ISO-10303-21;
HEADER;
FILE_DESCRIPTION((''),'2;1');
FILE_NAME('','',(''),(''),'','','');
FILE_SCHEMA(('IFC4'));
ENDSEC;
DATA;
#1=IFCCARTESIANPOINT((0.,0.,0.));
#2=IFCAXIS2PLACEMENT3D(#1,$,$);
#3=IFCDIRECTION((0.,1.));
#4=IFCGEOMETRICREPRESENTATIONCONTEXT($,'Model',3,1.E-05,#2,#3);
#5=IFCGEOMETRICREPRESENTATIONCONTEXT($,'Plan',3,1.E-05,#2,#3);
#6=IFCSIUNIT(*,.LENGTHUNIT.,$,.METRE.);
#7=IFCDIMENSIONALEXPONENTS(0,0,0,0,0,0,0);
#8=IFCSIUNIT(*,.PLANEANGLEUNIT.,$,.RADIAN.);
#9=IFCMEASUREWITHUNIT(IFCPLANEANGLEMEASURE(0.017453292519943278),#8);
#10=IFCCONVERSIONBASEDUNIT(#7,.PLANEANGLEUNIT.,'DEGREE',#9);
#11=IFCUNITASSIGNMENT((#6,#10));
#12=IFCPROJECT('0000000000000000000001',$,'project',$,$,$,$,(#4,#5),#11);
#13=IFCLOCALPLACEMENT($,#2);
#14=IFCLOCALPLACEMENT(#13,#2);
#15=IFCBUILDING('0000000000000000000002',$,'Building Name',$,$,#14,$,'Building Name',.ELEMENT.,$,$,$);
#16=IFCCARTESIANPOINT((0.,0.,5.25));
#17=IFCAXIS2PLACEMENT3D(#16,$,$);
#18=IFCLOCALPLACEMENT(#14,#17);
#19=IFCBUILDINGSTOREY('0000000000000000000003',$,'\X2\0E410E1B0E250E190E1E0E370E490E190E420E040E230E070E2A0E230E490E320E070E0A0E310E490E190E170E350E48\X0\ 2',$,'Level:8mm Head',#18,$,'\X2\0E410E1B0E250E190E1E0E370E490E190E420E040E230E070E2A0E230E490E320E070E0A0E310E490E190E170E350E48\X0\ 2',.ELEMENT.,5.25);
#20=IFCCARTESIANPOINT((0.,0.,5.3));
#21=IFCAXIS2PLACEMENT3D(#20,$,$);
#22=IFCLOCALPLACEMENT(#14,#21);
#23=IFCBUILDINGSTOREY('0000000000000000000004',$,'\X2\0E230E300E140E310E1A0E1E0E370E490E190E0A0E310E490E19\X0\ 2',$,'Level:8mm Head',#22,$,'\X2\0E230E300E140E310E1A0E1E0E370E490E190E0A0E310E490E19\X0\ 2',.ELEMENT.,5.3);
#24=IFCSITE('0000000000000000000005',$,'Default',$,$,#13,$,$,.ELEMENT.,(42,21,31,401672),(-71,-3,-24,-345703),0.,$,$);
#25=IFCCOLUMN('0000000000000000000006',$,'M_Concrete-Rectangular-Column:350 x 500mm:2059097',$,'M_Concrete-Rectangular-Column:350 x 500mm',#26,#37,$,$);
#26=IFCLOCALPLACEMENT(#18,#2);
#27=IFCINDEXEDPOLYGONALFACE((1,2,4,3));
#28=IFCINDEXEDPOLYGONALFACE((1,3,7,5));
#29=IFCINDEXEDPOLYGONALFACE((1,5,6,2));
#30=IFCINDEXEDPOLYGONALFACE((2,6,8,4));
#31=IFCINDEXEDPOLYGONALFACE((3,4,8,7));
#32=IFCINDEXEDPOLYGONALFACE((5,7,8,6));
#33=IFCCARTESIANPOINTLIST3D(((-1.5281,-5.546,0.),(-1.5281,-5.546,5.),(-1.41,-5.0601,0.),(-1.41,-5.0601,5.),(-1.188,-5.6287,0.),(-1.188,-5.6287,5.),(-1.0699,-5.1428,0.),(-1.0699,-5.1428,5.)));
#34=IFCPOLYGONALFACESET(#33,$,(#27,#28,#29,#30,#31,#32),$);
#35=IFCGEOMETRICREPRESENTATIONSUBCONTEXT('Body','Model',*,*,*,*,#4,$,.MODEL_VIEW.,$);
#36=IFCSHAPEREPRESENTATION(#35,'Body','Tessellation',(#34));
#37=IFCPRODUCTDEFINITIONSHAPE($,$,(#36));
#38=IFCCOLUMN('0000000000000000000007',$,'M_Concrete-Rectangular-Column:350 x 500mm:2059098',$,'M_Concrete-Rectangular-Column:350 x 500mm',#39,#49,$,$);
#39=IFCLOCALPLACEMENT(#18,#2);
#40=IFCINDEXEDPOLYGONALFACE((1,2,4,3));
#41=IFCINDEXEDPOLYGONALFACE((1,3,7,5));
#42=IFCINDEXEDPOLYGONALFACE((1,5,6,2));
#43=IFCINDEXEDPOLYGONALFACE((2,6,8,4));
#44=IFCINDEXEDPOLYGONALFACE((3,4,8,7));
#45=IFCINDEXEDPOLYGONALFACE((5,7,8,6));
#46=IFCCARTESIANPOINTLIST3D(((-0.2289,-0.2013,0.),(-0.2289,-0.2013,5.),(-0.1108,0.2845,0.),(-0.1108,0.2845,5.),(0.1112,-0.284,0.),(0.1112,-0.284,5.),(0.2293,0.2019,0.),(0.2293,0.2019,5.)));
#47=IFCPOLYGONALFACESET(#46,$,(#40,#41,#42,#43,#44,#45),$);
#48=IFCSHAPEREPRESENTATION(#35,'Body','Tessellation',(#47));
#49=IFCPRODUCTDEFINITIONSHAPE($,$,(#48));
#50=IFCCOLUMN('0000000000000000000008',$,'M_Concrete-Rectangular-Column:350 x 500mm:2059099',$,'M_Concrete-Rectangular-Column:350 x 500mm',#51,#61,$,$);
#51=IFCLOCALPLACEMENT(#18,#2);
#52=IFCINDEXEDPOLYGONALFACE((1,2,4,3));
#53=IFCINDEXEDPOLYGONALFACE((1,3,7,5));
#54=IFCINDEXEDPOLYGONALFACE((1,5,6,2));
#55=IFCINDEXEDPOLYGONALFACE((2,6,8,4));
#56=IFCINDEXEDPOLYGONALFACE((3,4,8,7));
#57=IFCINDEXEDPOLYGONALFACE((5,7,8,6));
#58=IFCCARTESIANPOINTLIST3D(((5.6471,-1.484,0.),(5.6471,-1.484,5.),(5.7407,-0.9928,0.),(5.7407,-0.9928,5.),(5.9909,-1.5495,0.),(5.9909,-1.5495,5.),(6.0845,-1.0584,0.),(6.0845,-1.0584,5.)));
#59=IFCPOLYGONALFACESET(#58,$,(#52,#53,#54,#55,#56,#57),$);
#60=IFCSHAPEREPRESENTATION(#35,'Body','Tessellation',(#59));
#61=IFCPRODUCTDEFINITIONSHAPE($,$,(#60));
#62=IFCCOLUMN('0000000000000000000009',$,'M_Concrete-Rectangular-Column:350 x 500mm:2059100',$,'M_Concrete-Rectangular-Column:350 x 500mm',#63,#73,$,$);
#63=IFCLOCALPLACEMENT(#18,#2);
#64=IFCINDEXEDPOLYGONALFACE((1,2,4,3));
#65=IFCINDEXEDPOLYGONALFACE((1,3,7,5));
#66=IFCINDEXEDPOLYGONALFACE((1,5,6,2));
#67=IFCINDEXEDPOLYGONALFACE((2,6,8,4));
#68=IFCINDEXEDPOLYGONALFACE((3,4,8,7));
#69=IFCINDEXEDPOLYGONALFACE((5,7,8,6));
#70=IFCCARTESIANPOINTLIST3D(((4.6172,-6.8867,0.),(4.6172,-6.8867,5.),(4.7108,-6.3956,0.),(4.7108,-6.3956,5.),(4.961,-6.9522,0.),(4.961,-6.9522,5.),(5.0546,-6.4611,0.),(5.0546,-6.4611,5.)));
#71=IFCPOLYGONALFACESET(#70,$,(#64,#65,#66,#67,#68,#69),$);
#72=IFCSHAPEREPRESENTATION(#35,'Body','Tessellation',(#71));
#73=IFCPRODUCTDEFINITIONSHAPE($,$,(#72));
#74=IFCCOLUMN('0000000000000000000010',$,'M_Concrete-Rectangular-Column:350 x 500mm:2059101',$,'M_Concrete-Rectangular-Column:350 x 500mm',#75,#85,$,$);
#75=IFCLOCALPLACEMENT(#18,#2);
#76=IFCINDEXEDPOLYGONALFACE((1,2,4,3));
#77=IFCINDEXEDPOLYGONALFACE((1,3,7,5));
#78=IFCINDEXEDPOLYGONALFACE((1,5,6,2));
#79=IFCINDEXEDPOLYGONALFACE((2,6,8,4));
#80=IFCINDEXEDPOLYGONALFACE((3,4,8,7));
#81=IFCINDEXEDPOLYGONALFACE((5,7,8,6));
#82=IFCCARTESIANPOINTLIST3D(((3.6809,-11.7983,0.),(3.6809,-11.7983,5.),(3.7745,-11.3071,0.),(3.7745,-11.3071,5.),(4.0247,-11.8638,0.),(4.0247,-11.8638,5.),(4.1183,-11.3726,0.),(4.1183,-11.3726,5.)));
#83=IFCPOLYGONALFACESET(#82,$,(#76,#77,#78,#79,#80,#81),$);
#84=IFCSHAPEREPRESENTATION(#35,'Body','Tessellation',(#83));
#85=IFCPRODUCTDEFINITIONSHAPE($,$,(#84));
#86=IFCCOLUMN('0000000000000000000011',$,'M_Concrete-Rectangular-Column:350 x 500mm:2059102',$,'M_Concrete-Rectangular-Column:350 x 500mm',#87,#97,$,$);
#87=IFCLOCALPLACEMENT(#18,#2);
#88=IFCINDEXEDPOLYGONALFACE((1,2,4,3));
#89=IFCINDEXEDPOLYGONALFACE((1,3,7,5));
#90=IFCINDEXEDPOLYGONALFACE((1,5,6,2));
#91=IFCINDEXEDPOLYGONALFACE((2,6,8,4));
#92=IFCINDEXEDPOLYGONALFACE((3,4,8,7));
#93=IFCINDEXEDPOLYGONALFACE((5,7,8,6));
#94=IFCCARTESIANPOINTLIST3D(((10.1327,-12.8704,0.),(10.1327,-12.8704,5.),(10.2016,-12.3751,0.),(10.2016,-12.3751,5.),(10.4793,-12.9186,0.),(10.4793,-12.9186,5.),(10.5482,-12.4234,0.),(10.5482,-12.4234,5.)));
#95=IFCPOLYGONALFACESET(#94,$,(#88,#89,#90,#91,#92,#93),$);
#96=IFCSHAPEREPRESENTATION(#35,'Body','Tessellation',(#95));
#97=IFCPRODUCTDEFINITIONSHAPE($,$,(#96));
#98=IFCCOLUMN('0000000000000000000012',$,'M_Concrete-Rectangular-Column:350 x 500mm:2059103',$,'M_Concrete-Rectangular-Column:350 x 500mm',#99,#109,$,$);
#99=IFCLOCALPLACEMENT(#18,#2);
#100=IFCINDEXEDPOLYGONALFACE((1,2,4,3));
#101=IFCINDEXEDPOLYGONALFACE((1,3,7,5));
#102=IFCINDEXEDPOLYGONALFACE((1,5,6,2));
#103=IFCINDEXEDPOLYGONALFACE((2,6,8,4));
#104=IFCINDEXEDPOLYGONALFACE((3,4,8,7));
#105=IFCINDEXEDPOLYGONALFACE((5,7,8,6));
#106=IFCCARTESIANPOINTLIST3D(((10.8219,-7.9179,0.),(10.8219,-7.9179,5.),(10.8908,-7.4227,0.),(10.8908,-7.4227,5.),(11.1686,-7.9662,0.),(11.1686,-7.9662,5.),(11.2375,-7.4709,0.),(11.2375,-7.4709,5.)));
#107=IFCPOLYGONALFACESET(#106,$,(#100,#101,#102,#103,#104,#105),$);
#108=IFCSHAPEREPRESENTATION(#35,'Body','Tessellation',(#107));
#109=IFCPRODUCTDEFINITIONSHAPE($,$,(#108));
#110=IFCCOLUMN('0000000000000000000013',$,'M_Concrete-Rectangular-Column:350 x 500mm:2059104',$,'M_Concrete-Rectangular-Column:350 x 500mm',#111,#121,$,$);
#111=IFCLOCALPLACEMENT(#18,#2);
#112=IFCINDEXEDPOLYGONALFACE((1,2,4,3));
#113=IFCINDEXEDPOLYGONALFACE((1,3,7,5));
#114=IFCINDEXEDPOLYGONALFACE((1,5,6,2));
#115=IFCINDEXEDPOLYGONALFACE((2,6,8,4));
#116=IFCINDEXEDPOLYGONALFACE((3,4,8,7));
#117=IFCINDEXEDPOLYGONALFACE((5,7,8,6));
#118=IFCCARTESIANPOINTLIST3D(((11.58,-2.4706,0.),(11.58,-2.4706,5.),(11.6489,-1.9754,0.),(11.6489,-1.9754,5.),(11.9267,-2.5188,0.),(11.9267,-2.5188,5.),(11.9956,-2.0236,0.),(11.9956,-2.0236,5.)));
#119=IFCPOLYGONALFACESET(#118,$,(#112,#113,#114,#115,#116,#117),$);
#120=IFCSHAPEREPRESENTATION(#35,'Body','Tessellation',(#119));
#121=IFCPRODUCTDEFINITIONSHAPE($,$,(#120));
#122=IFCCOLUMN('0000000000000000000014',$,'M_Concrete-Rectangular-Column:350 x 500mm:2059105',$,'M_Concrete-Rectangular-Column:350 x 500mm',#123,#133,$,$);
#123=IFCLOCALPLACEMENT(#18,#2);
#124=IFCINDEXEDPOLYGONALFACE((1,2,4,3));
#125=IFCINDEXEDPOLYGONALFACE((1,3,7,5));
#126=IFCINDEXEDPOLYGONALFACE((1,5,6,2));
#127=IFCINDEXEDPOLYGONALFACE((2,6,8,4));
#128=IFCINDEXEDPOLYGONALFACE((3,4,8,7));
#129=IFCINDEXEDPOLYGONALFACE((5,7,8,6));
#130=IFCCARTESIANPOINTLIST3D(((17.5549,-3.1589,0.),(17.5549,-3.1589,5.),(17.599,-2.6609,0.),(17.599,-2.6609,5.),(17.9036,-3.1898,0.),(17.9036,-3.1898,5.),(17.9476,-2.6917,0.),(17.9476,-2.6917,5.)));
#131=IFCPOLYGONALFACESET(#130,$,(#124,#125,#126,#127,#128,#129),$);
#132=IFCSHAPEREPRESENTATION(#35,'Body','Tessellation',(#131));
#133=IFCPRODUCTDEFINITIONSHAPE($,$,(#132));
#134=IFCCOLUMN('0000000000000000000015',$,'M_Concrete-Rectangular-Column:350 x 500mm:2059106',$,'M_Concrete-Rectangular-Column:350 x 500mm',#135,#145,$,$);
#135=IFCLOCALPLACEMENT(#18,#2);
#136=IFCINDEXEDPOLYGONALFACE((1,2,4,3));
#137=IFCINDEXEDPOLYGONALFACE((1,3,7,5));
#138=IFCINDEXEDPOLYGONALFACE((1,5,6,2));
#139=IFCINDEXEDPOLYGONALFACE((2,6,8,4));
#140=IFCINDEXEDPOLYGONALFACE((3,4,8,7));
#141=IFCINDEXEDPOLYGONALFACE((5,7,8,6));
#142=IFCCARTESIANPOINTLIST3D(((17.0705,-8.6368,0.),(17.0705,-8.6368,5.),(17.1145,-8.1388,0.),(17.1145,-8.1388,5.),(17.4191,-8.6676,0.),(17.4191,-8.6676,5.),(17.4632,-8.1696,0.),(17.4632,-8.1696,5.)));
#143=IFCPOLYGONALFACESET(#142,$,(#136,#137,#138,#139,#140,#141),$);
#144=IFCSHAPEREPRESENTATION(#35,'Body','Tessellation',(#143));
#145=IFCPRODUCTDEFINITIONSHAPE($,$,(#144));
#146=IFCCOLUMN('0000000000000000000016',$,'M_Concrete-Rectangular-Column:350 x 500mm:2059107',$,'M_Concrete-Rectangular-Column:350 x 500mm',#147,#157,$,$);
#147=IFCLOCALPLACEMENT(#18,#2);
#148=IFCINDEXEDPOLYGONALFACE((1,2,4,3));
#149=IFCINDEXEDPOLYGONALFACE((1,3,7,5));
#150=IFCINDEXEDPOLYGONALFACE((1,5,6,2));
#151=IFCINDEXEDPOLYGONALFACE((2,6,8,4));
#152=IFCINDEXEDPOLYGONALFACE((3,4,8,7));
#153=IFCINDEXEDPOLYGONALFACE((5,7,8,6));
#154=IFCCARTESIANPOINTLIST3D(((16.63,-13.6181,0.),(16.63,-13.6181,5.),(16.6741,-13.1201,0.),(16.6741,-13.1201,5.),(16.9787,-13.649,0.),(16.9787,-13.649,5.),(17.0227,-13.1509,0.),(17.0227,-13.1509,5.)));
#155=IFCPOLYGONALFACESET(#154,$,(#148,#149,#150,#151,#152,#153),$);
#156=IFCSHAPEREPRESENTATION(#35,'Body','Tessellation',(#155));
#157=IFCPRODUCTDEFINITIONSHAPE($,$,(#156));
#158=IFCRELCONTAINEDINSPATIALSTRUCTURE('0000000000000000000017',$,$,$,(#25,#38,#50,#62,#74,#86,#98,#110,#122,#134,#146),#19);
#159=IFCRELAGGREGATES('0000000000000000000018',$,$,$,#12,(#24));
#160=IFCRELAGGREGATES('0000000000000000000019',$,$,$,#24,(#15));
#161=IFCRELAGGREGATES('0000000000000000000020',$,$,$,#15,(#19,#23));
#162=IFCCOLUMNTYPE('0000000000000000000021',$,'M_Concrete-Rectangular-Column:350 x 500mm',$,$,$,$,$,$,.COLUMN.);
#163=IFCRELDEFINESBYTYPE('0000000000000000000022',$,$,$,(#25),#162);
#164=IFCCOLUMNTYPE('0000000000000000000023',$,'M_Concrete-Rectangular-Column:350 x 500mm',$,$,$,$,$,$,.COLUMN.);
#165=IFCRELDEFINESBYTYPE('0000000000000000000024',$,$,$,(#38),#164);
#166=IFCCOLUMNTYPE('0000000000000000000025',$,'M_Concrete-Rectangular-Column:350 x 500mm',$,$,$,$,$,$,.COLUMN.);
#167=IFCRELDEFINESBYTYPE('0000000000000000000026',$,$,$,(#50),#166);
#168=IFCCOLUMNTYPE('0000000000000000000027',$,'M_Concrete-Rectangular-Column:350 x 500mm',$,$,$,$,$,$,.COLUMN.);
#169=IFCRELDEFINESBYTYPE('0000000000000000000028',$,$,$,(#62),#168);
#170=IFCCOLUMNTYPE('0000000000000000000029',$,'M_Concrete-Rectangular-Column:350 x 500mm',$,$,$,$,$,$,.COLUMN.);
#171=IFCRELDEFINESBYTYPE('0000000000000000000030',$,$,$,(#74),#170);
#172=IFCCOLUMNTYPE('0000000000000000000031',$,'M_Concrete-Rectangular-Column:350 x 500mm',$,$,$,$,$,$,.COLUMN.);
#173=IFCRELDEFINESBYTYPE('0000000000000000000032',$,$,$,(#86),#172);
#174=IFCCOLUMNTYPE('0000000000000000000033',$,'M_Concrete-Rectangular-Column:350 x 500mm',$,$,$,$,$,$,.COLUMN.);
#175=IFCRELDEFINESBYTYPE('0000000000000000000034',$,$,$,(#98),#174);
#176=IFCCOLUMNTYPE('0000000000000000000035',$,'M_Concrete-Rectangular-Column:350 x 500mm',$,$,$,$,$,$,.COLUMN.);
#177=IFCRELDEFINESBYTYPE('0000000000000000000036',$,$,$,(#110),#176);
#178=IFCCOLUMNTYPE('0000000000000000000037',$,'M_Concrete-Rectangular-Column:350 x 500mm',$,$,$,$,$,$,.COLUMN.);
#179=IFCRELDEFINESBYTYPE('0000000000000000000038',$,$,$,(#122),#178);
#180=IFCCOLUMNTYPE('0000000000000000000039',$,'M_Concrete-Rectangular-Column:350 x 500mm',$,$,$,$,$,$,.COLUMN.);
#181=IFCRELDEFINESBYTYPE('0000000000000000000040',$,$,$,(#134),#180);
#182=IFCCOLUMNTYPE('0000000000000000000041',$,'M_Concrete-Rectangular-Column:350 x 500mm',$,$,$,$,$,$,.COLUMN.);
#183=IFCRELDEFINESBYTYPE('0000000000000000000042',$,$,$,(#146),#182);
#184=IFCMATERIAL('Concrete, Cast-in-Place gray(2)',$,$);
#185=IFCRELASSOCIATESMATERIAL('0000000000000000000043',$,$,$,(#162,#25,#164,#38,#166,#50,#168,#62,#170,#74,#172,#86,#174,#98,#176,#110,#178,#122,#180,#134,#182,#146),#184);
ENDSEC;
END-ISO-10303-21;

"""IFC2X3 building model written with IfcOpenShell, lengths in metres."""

from ifc_helpers import new_model, entity, si_unit, converted_unit, direction, frame, frame_2d, origin, origin_2d_with_axis, place, context, subcontext, project, spatial, rectangle, extrude, source, transform, mapped, material, type_object, type_shapes, element, save


model = new_model("IFC2X3")

# Units and contexts
model_context = context("Model", 3, precision=1e-05, world=origin(), true_north=direction((0.0, 1.0)))
plan_context = context("Plan", 3, precision=1e-05, world=origin(), true_north=direction((0.0, 1.0)))
body_context = subcontext(model_context, "Body", "Model", "MODEL_VIEW")
ifc_project = project(units=[si_unit("LENGTHUNIT", "METRE"), converted_unit("PLANEANGLEUNIT", "DEGREE", entity("IfcPlaneAngleMeasure", 0.017453292519943278), si_unit("PLANEANGLEUNIT", "RADIAN"), dimensions=[0, 0, 0, 0, 0, 0, 0])], contexts=[model_context, plan_context])

# Site, building, storey
site_placement = place(None, origin())
site = spatial("IfcSite", under=ifc_project, at=site_placement, Name="Default", CompositionType="ELEMENT", RefLatitude=(42, 21, 31, 401672), RefLongitude=(-71, -3, -24, -345703), RefElevation=0.0)
building_placement = place(site_placement, origin())
building = spatial("IfcBuilding", under=site, at=building_placement, Name="Building Name", LongName="Building Name", CompositionType="ELEMENT")
storey_1_placement = place(building_placement, frame((0.0, 0.0, 5.25)))
storey_1 = spatial("IfcBuildingStorey", under=building, at=storey_1_placement, Name="แปลนพื้นโครงสร้างชั้นที่ 2", ObjectType="Level:8mm Head", LongName="แปลนพื้นโครงสร้างชั้นที่ 2", CompositionType="ELEMENT", Elevation=5.25)

# Columns
ifc_material_1 = material(Name="Concrete, Cast-in-Place gray(2)")
column_type_1 = type_object("IfcColumnType", Name="M_Concrete-Rectangular-Column:350 x 500mm", PredefinedType="COLUMN", material=ifc_material_1)
shared_shape_1 = source(origin(), body_context, "Body", "SweptSolid", [
    extrude(rectangle(XDim=0.35, YDim=0.5, at=frame_2d((0.0, 0.0), x_axis=(1.0, 0.0))), frame((-1.299, -5.3444, 5.25), z_axis=(0.0, 0.0, 1.0), x_axis=(0.971704, -0.236201, 0.0)), (0.0, 0.0, 1.0), 5.0),
])
type_shapes(column_type_1, [shared_shape_1])
column_1_placement = place(storey_1_placement, frame((0.0, 0.0, -5.25)))
element("IfcColumn", 1, at=column_1_placement, inside=storey_1, type_object=column_type_1, material=ifc_material_1, Name="M_Concrete-Rectangular-Column:350 x 500mm:2059097", ObjectType="M_Concrete-Rectangular-Column:350 x 500mm", context=body_context, shape_type="MappedRepresentation", body=[
    mapped(shared_shape_1, transform((0.0, 0.0, 0.0), scale=1.0)),
])
column_type_2 = type_object("IfcColumnType", Name="M_Concrete-Rectangular-Column:350 x 500mm", PredefinedType="COLUMN", material=ifc_material_1)
shared_shape_2 = source(origin(), body_context, "Body", "SweptSolid", [
    extrude(rectangle(XDim=0.35, YDim=0.5, at=frame_2d((0.0, 0.0), x_axis=(1.0, 0.0))), frame((0.0002, 0.0003, 5.25), z_axis=(0.0, 0.0, 1.0), x_axis=(0.971704, -0.236201, 0.0)), (0.0, 0.0, 1.0), 5.0),
])
type_shapes(column_type_2, [shared_shape_2])
column_2_placement = place(storey_1_placement, frame((0.0, 0.0, -5.25)))
element("IfcColumn", 2, at=column_2_placement, inside=storey_1, type_object=column_type_2, material=ifc_material_1, Name="M_Concrete-Rectangular-Column:350 x 500mm:2059098", ObjectType="M_Concrete-Rectangular-Column:350 x 500mm", context=body_context, shape_type="MappedRepresentation", body=[
    mapped(shared_shape_2, transform((0.0, 0.0, 0.0), scale=1.0)),
])
column_type_3 = type_object("IfcColumnType", Name="M_Concrete-Rectangular-Column:350 x 500mm", PredefinedType="COLUMN", material=ifc_material_1)
shared_shape_3 = source(origin(), body_context, "Body", "SweptSolid", [
    extrude(rectangle(XDim=0.35, YDim=0.5, at=frame_2d((0.0, 0.0), x_axis=(1.0, 0.0))), frame((5.8658, -1.2712, 5.25), z_axis=(0.0, 0.0, 1.0), x_axis=(0.982311, -0.187257, 0.0)), (0.0, 0.0, 1.0), 5.0),
])
type_shapes(column_type_3, [shared_shape_3])
column_3_placement = place(storey_1_placement, frame((0.0, 0.0, -5.25)))
element("IfcColumn", 3, at=column_3_placement, inside=storey_1, type_object=column_type_3, material=ifc_material_1, Name="M_Concrete-Rectangular-Column:350 x 500mm:2059099", ObjectType="M_Concrete-Rectangular-Column:350 x 500mm", context=body_context, shape_type="MappedRepresentation", body=[
    mapped(shared_shape_3, transform((0.0, 0.0, 0.0), scale=1.0)),
])
column_type_4 = type_object("IfcColumnType", Name="M_Concrete-Rectangular-Column:350 x 500mm", PredefinedType="COLUMN", material=ifc_material_1)
shared_shape_4 = source(origin(), body_context, "Body", "SweptSolid", [
    extrude(rectangle(XDim=0.35, YDim=0.5, at=frame_2d((0.0, 0.0), x_axis=(1.0, 0.0))), frame((4.8359, -6.6739, 5.25), z_axis=(0.0, 0.0, 1.0), x_axis=(-0.982311, 0.187257, 0.0)), (0.0, 0.0, 1.0), 5.0),
])
type_shapes(column_type_4, [shared_shape_4])
column_4_placement = place(storey_1_placement, frame((0.0, 0.0, -5.25)))
element("IfcColumn", 4, at=column_4_placement, inside=storey_1, type_object=column_type_4, material=ifc_material_1, Name="M_Concrete-Rectangular-Column:350 x 500mm:2059100", ObjectType="M_Concrete-Rectangular-Column:350 x 500mm", context=body_context, shape_type="MappedRepresentation", body=[
    mapped(shared_shape_4, transform((0.0, 0.0, 0.0), scale=1.0)),
])
column_type_5 = type_object("IfcColumnType", Name="M_Concrete-Rectangular-Column:350 x 500mm", PredefinedType="COLUMN", material=ifc_material_1)
shared_shape_5 = source(origin(), body_context, "Body", "SweptSolid", [
    extrude(rectangle(XDim=0.35, YDim=0.5, at=frame_2d((0.0, 0.0), x_axis=(1.0, 0.0))), frame((3.8996, -11.5855, 5.25), z_axis=(0.0, 0.0, 1.0), x_axis=(-0.982311, 0.187257, 0.0)), (0.0, 0.0, 1.0), 5.0),
])
type_shapes(column_type_5, [shared_shape_5])
column_5_placement = place(storey_1_placement, frame((0.0, 0.0, -5.25)))
element("IfcColumn", 5, at=column_5_placement, inside=storey_1, type_object=column_type_5, material=ifc_material_1, Name="M_Concrete-Rectangular-Column:350 x 500mm:2059101", ObjectType="M_Concrete-Rectangular-Column:350 x 500mm", context=body_context, shape_type="MappedRepresentation", body=[
    mapped(shared_shape_5, transform((0.0, 0.0, 0.0), scale=1.0)),
])
column_type_6 = type_object("IfcColumnType", Name="M_Concrete-Rectangular-Column:350 x 500mm", PredefinedType="COLUMN", material=ifc_material_1)
shared_shape_6 = source(origin(), body_context, "Body", "SweptSolid", [
    extrude(rectangle(XDim=0.35, YDim=0.5, at=frame_2d((0.0, 0.0), x_axis=(1.0, 0.0))), frame((10.3404, -12.6469, 5.25), z_axis=(0.0, 0.0, 1.0), x_axis=(-0.990454, 0.137844, 0.0)), (0.0, 0.0, 1.0), 5.0),
])
type_shapes(column_type_6, [shared_shape_6])
column_6_placement = place(storey_1_placement, frame((0.0, 0.0, -5.25)))
element("IfcColumn", 6, at=column_6_placement, inside=storey_1, type_object=column_type_6, material=ifc_material_1, Name="M_Concrete-Rectangular-Column:350 x 500mm:2059102", ObjectType="M_Concrete-Rectangular-Column:350 x 500mm", context=body_context, shape_type="MappedRepresentation", body=[
    mapped(shared_shape_6, transform((0.0, 0.0, 0.0), scale=1.0)),
])
column_type_7 = type_object("IfcColumnType", Name="M_Concrete-Rectangular-Column:350 x 500mm", PredefinedType="COLUMN", material=ifc_material_1)
shared_shape_7 = source(origin(), body_context, "Body", "SweptSolid", [
    extrude(rectangle(XDim=0.35, YDim=0.5, at=origin_2d_with_axis()), frame((11.0297, -7.6944, 5.25), z_axis=(0.0, 0.0, 1.0), x_axis=(-0.990454, 0.137844, 0.0)), (0.0, 0.0, 1.0), 5.0),
])
type_shapes(column_type_7, [shared_shape_7])
column_7_placement = place(storey_1_placement, frame((0.0, 0.0, -5.25)))
element("IfcColumn", 7, at=column_7_placement, inside=storey_1, type_object=column_type_7, material=ifc_material_1, Name="M_Concrete-Rectangular-Column:350 x 500mm:2059103", ObjectType="M_Concrete-Rectangular-Column:350 x 500mm", context=body_context, shape_type="MappedRepresentation", body=[
    mapped(shared_shape_7, transform((0.0, 0.0, 0.0), scale=1.0)),
])
column_type_8 = type_object("IfcColumnType", Name="M_Concrete-Rectangular-Column:350 x 500mm", PredefinedType="COLUMN", material=ifc_material_1)
shared_shape_8 = source(origin(), body_context, "Body", "SweptSolid", [
    extrude(rectangle(XDim=0.35, YDim=0.5, at=origin_2d_with_axis()), frame((11.7878, -2.2471, 5.25), z_axis=(0.0, 0.0, 1.0), x_axis=(-0.990454, 0.137844, 0.0)), (0.0, 0.0, 1.0), 5.0),
])
type_shapes(column_type_8, [shared_shape_8])
column_8_placement = place(storey_1_placement, frame((0.0, 0.0, -5.25)))
element("IfcColumn", 8, at=column_8_placement, inside=storey_1, type_object=column_type_8, material=ifc_material_1, Name="M_Concrete-Rectangular-Column:350 x 500mm:2059104", ObjectType="M_Concrete-Rectangular-Column:350 x 500mm", context=body_context, shape_type="MappedRepresentation", body=[
    mapped(shared_shape_8, transform((0.0, 0.0, 0.0), scale=1.0)),
])
column_type_9 = type_object("IfcColumnType", Name="M_Concrete-Rectangular-Column:350 x 500mm", PredefinedType="COLUMN", material=ifc_material_1)
shared_shape_9 = source(origin(), body_context, "Body", "SweptSolid", [
    extrude(rectangle(XDim=0.35, YDim=0.5, at=frame_2d((0.0, 0.0), x_axis=(1.0, 0.0))), frame((17.7513, -2.9253, 5.25), z_axis=(0.0, 0.0, 1.0), x_axis=(0.996113, -0.088086, 0.0)), (0.0, 0.0, 1.0), 5.0),
])
type_shapes(column_type_9, [shared_shape_9])
column_9_placement = place(storey_1_placement, frame((0.0, 0.0, -5.25)))
element("IfcColumn", 9, at=column_9_placement, inside=storey_1, type_object=column_type_9, material=ifc_material_1, Name="M_Concrete-Rectangular-Column:350 x 500mm:2059105", ObjectType="M_Concrete-Rectangular-Column:350 x 500mm", context=body_context, shape_type="MappedRepresentation", body=[
    mapped(shared_shape_9, transform((0.0, 0.0, 0.0), scale=1.0)),
])
column_type_10 = type_object("IfcColumnType", Name="M_Concrete-Rectangular-Column:350 x 500mm", PredefinedType="COLUMN", material=ifc_material_1)
shared_shape_10 = source(origin(), body_context, "Body", "SweptSolid", [
    extrude(rectangle(XDim=0.35, YDim=0.5, at=origin_2d_with_axis()), frame((17.2668, -8.4032, 5.25), z_axis=(0.0, 0.0, 1.0), x_axis=(0.996113, -0.088086, 0.0)), (0.0, 0.0, 1.0), 5.0),
])
type_shapes(column_type_10, [shared_shape_10])
column_10_placement = place(storey_1_placement, frame((0.0, 0.0, -5.25)))
element("IfcColumn", 10, at=column_10_placement, inside=storey_1, type_object=column_type_10, material=ifc_material_1, Name="M_Concrete-Rectangular-Column:350 x 500mm:2059106", ObjectType="M_Concrete-Rectangular-Column:350 x 500mm", context=body_context, shape_type="MappedRepresentation", body=[
    mapped(shared_shape_10, transform((0.0, 0.0, 0.0), scale=1.0)),
])
column_type_11 = type_object("IfcColumnType", Name="M_Concrete-Rectangular-Column:350 x 500mm", PredefinedType="COLUMN", material=ifc_material_1)
shared_shape_11 = source(origin(), body_context, "Body", "SweptSolid", [
    extrude(rectangle(XDim=0.35, YDim=0.5, at=frame_2d((0.0, 0.0), x_axis=(1.0, 0.0))), frame((16.8264, -13.3845, 5.25), z_axis=(0.0, 0.0, 1.0), x_axis=(0.996113, -0.088086, 0.0)), (0.0, 0.0, 1.0), 5.0),
])
type_shapes(column_type_11, [shared_shape_11])
column_11_placement = place(storey_1_placement, frame((0.0, 0.0, -5.25)))
element("IfcColumn", 11, at=column_11_placement, inside=storey_1, type_object=column_type_11, material=ifc_material_1, Name="M_Concrete-Rectangular-Column:350 x 500mm:2059107", ObjectType="M_Concrete-Rectangular-Column:350 x 500mm", context=body_context, shape_type="MappedRepresentation", body=[
    mapped(shared_shape_11, transform((0.0, 0.0, 0.0), scale=1.0)),
])

# Shared definitions
storey_2_placement = place(building_placement, frame((0.0, 0.0, 5.3)))
storey_2 = spatial("IfcBuildingStorey", under=building, at=storey_2_placement, Name="ระดับพื้นชั้น 2", ObjectType="Level:8mm Head", LongName="ระดับพื้นชั้น 2", CompositionType="ELEMENT", Elevation=5.3)

save(model, "model.ifc")
